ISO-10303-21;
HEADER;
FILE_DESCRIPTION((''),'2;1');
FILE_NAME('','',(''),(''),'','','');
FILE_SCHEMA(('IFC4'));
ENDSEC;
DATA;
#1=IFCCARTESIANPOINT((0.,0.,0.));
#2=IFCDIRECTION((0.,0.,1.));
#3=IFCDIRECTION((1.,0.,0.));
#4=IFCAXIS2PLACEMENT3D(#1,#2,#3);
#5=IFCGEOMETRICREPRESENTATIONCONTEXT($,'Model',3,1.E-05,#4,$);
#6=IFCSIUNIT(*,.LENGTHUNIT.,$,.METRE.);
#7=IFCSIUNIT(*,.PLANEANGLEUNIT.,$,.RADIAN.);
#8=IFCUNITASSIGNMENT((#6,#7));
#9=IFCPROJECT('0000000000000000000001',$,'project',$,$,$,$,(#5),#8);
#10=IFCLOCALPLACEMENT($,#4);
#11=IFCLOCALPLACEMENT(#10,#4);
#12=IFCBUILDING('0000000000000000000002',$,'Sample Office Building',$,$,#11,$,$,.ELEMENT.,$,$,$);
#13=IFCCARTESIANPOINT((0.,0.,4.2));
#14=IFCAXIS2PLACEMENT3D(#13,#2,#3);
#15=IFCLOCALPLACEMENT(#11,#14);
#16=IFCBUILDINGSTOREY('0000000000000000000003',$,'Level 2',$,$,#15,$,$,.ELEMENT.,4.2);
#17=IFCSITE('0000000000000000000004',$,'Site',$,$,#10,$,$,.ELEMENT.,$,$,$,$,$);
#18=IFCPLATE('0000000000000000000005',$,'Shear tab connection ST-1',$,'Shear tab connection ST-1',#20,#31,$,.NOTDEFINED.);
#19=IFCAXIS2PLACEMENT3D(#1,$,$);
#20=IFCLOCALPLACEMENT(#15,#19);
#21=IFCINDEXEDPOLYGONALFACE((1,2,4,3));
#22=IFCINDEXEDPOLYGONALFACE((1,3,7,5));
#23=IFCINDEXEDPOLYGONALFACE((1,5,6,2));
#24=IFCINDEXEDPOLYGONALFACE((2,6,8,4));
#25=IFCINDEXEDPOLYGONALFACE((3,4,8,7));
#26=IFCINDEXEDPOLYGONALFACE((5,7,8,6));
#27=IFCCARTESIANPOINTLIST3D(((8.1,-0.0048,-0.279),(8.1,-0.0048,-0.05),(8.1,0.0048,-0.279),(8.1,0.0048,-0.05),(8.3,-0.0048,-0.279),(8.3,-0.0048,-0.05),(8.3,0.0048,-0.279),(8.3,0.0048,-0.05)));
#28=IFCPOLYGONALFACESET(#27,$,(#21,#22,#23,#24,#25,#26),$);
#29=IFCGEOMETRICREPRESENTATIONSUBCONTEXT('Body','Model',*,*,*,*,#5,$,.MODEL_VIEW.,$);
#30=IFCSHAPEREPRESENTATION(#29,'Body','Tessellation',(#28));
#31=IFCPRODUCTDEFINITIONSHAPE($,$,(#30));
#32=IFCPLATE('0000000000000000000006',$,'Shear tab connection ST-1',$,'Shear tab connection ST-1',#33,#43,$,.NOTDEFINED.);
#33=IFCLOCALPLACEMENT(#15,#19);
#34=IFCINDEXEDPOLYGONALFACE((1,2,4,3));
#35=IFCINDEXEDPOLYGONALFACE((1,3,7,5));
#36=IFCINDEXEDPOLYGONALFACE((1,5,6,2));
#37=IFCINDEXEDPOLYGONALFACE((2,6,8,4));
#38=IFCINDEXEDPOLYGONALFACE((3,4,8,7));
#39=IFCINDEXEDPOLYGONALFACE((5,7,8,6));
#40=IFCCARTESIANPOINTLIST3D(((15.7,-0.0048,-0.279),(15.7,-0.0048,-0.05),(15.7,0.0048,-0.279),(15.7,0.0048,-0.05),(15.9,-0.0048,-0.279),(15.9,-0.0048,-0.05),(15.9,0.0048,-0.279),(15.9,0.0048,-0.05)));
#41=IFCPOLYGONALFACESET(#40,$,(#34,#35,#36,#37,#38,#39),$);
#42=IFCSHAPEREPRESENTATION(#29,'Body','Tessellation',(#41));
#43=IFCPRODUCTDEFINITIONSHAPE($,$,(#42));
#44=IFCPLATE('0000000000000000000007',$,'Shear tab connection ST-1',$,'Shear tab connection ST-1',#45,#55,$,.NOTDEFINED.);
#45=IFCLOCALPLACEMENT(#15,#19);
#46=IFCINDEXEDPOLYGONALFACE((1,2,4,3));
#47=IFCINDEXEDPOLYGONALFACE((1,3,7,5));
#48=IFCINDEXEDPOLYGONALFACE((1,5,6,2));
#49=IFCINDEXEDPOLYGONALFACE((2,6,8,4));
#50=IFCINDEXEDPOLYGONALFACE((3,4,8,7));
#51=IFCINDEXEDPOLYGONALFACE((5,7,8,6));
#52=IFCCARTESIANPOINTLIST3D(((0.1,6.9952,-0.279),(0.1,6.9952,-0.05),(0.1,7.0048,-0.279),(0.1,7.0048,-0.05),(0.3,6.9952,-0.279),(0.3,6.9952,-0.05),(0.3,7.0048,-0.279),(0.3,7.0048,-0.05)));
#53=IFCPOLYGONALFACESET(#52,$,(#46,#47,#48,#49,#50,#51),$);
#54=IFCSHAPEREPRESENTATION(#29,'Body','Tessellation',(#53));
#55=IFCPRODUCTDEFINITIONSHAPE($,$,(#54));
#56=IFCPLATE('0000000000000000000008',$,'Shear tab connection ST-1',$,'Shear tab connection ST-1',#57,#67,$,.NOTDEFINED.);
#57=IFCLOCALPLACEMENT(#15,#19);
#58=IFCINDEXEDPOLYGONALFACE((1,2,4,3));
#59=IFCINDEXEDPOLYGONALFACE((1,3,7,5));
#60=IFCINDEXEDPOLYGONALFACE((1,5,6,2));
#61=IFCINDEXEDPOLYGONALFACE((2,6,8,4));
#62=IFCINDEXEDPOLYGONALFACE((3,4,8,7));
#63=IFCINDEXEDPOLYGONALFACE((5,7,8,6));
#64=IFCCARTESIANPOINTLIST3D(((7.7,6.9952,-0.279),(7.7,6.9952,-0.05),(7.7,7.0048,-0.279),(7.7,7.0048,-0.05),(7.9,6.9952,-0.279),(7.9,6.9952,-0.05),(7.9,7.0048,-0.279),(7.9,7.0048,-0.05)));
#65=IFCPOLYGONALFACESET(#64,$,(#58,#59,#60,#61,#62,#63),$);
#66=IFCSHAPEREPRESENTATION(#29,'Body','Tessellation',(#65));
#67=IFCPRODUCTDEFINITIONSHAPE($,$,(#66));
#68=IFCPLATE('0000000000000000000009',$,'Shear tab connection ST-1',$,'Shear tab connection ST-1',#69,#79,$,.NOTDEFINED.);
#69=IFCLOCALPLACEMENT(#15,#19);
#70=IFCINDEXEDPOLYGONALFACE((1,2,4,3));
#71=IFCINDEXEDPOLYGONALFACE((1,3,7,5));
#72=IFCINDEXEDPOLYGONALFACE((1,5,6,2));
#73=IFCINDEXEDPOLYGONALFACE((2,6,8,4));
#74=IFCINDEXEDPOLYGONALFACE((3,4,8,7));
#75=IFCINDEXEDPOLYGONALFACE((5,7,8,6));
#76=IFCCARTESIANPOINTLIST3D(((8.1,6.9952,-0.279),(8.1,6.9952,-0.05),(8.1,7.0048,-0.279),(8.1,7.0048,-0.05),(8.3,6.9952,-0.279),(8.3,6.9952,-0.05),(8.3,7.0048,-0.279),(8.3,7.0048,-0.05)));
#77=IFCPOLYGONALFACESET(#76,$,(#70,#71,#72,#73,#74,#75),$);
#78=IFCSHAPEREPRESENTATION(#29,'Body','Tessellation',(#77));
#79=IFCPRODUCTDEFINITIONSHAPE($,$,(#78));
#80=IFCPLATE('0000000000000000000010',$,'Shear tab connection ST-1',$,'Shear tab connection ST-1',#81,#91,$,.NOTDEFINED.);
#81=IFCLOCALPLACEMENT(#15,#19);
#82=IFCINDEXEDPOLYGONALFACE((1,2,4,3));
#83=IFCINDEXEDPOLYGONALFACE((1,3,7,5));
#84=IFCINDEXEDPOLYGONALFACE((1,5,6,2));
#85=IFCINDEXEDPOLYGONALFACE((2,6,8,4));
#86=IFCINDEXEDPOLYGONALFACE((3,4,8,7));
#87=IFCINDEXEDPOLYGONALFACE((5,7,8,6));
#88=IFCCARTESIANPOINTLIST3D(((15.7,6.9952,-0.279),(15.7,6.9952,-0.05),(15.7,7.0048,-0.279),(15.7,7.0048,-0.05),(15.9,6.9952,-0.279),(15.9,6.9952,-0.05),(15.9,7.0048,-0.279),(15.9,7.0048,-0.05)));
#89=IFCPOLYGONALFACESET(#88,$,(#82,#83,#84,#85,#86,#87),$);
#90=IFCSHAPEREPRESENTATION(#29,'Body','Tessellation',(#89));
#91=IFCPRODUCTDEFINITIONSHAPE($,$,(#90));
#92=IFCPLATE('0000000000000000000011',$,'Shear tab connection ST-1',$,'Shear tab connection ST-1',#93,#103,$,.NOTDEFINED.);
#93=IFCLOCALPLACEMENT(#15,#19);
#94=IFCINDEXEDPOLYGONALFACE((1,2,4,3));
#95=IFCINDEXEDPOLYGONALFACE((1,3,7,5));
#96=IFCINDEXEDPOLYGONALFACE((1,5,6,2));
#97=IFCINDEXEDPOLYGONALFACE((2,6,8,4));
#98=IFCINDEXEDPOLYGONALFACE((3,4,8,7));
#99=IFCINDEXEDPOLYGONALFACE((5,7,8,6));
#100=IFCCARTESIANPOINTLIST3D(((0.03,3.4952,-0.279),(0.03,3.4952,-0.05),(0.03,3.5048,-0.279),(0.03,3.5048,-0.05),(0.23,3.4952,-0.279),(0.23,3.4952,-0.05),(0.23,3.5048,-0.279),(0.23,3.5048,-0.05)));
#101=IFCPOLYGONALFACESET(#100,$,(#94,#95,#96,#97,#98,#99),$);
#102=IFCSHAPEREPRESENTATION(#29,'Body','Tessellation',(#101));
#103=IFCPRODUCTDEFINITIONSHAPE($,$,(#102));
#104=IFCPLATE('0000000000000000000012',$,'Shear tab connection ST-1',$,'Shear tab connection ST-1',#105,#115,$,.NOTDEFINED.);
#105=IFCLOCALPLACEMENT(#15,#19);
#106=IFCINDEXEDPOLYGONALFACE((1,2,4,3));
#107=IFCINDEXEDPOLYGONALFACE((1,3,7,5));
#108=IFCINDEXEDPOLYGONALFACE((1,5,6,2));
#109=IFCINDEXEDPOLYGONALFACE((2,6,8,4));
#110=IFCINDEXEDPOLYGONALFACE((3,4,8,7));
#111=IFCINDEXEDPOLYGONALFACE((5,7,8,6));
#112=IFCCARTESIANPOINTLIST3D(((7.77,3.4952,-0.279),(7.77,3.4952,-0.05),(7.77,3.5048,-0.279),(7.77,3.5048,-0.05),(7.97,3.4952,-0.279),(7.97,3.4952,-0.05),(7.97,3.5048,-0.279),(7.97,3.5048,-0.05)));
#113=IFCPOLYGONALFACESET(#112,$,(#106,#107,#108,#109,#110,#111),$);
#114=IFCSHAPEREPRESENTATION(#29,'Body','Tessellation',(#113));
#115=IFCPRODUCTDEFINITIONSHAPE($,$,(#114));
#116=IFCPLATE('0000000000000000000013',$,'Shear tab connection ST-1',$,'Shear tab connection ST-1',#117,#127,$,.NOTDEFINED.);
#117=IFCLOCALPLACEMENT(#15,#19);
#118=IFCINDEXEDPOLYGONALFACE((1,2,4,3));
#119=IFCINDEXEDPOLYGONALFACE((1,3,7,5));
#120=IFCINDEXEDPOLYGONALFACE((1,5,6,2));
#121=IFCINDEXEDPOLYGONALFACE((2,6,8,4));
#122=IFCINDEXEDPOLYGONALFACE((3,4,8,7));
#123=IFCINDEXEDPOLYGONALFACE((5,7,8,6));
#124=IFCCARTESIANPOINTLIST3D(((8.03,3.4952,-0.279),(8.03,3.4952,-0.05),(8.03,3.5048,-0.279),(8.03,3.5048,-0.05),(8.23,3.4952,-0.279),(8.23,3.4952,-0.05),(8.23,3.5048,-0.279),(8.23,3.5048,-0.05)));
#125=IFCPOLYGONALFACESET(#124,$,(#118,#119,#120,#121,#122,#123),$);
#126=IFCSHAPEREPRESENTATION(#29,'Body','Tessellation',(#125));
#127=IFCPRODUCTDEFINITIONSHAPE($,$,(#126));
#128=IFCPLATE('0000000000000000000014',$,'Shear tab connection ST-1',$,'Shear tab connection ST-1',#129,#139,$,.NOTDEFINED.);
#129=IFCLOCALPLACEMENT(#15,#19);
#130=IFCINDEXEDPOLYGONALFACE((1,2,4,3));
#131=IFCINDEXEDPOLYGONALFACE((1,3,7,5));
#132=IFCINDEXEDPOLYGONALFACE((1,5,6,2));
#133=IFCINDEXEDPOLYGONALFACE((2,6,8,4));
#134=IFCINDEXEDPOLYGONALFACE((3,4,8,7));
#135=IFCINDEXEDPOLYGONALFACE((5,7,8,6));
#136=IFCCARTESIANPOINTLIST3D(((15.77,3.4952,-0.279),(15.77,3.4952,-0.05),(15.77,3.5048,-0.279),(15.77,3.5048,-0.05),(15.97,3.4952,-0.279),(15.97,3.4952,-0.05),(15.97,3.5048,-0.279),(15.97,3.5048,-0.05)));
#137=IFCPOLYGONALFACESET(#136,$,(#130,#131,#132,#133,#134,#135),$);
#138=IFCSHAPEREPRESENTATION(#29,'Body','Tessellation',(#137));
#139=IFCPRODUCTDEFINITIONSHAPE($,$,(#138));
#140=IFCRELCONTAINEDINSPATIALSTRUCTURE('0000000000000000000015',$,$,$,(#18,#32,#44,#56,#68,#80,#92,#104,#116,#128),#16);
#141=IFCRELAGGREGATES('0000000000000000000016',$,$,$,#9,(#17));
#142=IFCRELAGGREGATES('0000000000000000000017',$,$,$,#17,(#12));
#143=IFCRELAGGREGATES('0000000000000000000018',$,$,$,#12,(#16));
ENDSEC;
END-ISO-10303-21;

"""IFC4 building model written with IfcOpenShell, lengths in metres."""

from ifc_helpers import new_model, si_unit, frame, origin_with_axes, place, context, subcontext, project, spatial, rectangle, extrude, element, save


model = new_model("IFC4")

# Units and contexts
model_context = context("Model", 3, precision=1e-05, world=origin_with_axes())
body_context = subcontext(model_context, "Body", "Model", "MODEL_VIEW")
ifc_project = project(units=[si_unit("LENGTHUNIT", "METRE"), si_unit("PLANEANGLEUNIT", "RADIAN")], contexts=[model_context])

# Site, building, storey
site_placement = place(None, origin_with_axes())
site = spatial("IfcSite", under=ifc_project, at=site_placement, Name="Site", CompositionType="ELEMENT")
building_placement = place(site_placement, origin_with_axes())
building = spatial("IfcBuilding", under=site, at=building_placement, Name="Sample Office Building", CompositionType="ELEMENT")
storey_placement = place(building_placement, frame((0.0, 0.0, 4.2), z_axis=(0.0, 0.0, 1.0), x_axis=(1.0, 0.0, 0.0)))
storey = spatial("IfcBuildingStorey", under=building, at=storey_placement, Name="Level 2", CompositionType="ELEMENT", Elevation=4.2)

# Plates
for number, where, z_axis, x_axis, name in (
    (1, (8.2, 0.0, 3.921), (0.0, 0.0, 1.0), (1.0, 0.0, 0.0), "Shear tab connection ST-1"),
    (2, (15.8, 0.0, 3.921), (0.0, 0.0, 1.0), (1.0, 0.0, 0.0), "Shear tab connection ST-1"),
):
    element("IfcPlate", number, at=place(None, frame(where, z_axis=z_axis, x_axis=x_axis)), inside=storey, Name=name, ObjectType="Shear tab connection ST-1", PredefinedType="NOTDEFINED", context=body_context, shape_type="SweptSolid", body=[
        extrude(rectangle(XDim=0.2, YDim=0.0095), None, (0.0, 0.0, 1.0), 0.229),
    ])
plate_1_placement = place(None, frame((0.2, 7.0, 3.921), z_axis=(0.0, 0.0, 1.0), x_axis=(1.0, 0.0, 0.0)))
element("IfcPlate", 3, at=plate_1_placement, inside=storey, Name="Shear tab connection ST-1", ObjectType="Shear tab connection ST-1", PredefinedType="NOTDEFINED", context=body_context, shape_type="SweptSolid", body=[
    extrude(rectangle(XDim=0.2, YDim=0.0095), None, (0.0, 0.0, 1.0), 0.229),
])
plate_2_placement = place(None, frame((7.8, 7.0, 3.921), z_axis=(0.0, 0.0, 1.0), x_axis=(1.0, 0.0, 0.0)))
element("IfcPlate", 4, at=plate_2_placement, inside=storey, Name="Shear tab connection ST-1", ObjectType="Shear tab connection ST-1", PredefinedType="NOTDEFINED", context=body_context, shape_type="SweptSolid", body=[
    extrude(rectangle(XDim=0.2, YDim=0.0095), None, (0.0, 0.0, 1.0), 0.229),
])
for number, where, z_axis, x_axis, name in (
    (5, (8.2, 7.0, 3.921), (0.0, 0.0, 1.0), (1.0, 0.0, 0.0), "Shear tab connection ST-1"),
    (6, (15.8, 7.0, 3.921), (0.0, 0.0, 1.0), (1.0, 0.0, 0.0), "Shear tab connection ST-1"),
):
    element("IfcPlate", number, at=place(None, frame(where, z_axis=z_axis, x_axis=x_axis)), inside=storey, Name=name, ObjectType="Shear tab connection ST-1", PredefinedType="NOTDEFINED", context=body_context, shape_type="SweptSolid", body=[
        extrude(rectangle(XDim=0.2, YDim=0.0095), None, (0.0, 0.0, 1.0), 0.229),
    ])
plate_3_placement = place(None, frame((0.13, 3.5, 3.921), z_axis=(0.0, 0.0, 1.0), x_axis=(1.0, 0.0, 0.0)))
element("IfcPlate", 7, at=plate_3_placement, inside=storey, Name="Shear tab connection ST-1", ObjectType="Shear tab connection ST-1", PredefinedType="NOTDEFINED", context=body_context, shape_type="SweptSolid", body=[
    extrude(rectangle(XDim=0.2, YDim=0.0095), None, (0.0, 0.0, 1.0), 0.229),
])
plate_4_placement = place(None, frame((7.87, 3.5, 3.921), z_axis=(0.0, 0.0, 1.0), x_axis=(1.0, 0.0, 0.0)))
element("IfcPlate", 8, at=plate_4_placement, inside=storey, Name="Shear tab connection ST-1", ObjectType="Shear tab connection ST-1", PredefinedType="NOTDEFINED", context=body_context, shape_type="SweptSolid", body=[
    extrude(rectangle(XDim=0.2, YDim=0.0095), None, (0.0, 0.0, 1.0), 0.229),
])
for number, where, z_axis, x_axis, name in (
    (9, (8.13, 3.5, 3.921), (0.0, 0.0, 1.0), (1.0, 0.0, 0.0), "Shear tab connection ST-1"),
    (10, (15.87, 3.5, 3.921), (0.0, 0.0, 1.0), (1.0, 0.0, 0.0), "Shear tab connection ST-1"),
):
    element("IfcPlate", number, at=place(None, frame(where, z_axis=z_axis, x_axis=x_axis)), inside=storey, Name=name, ObjectType="Shear tab connection ST-1", PredefinedType="NOTDEFINED", context=body_context, shape_type="SweptSolid", body=[
        extrude(rectangle(XDim=0.2, YDim=0.0095), None, (0.0, 0.0, 1.0), 0.229),
    ])

save(model, "model.ifc")
